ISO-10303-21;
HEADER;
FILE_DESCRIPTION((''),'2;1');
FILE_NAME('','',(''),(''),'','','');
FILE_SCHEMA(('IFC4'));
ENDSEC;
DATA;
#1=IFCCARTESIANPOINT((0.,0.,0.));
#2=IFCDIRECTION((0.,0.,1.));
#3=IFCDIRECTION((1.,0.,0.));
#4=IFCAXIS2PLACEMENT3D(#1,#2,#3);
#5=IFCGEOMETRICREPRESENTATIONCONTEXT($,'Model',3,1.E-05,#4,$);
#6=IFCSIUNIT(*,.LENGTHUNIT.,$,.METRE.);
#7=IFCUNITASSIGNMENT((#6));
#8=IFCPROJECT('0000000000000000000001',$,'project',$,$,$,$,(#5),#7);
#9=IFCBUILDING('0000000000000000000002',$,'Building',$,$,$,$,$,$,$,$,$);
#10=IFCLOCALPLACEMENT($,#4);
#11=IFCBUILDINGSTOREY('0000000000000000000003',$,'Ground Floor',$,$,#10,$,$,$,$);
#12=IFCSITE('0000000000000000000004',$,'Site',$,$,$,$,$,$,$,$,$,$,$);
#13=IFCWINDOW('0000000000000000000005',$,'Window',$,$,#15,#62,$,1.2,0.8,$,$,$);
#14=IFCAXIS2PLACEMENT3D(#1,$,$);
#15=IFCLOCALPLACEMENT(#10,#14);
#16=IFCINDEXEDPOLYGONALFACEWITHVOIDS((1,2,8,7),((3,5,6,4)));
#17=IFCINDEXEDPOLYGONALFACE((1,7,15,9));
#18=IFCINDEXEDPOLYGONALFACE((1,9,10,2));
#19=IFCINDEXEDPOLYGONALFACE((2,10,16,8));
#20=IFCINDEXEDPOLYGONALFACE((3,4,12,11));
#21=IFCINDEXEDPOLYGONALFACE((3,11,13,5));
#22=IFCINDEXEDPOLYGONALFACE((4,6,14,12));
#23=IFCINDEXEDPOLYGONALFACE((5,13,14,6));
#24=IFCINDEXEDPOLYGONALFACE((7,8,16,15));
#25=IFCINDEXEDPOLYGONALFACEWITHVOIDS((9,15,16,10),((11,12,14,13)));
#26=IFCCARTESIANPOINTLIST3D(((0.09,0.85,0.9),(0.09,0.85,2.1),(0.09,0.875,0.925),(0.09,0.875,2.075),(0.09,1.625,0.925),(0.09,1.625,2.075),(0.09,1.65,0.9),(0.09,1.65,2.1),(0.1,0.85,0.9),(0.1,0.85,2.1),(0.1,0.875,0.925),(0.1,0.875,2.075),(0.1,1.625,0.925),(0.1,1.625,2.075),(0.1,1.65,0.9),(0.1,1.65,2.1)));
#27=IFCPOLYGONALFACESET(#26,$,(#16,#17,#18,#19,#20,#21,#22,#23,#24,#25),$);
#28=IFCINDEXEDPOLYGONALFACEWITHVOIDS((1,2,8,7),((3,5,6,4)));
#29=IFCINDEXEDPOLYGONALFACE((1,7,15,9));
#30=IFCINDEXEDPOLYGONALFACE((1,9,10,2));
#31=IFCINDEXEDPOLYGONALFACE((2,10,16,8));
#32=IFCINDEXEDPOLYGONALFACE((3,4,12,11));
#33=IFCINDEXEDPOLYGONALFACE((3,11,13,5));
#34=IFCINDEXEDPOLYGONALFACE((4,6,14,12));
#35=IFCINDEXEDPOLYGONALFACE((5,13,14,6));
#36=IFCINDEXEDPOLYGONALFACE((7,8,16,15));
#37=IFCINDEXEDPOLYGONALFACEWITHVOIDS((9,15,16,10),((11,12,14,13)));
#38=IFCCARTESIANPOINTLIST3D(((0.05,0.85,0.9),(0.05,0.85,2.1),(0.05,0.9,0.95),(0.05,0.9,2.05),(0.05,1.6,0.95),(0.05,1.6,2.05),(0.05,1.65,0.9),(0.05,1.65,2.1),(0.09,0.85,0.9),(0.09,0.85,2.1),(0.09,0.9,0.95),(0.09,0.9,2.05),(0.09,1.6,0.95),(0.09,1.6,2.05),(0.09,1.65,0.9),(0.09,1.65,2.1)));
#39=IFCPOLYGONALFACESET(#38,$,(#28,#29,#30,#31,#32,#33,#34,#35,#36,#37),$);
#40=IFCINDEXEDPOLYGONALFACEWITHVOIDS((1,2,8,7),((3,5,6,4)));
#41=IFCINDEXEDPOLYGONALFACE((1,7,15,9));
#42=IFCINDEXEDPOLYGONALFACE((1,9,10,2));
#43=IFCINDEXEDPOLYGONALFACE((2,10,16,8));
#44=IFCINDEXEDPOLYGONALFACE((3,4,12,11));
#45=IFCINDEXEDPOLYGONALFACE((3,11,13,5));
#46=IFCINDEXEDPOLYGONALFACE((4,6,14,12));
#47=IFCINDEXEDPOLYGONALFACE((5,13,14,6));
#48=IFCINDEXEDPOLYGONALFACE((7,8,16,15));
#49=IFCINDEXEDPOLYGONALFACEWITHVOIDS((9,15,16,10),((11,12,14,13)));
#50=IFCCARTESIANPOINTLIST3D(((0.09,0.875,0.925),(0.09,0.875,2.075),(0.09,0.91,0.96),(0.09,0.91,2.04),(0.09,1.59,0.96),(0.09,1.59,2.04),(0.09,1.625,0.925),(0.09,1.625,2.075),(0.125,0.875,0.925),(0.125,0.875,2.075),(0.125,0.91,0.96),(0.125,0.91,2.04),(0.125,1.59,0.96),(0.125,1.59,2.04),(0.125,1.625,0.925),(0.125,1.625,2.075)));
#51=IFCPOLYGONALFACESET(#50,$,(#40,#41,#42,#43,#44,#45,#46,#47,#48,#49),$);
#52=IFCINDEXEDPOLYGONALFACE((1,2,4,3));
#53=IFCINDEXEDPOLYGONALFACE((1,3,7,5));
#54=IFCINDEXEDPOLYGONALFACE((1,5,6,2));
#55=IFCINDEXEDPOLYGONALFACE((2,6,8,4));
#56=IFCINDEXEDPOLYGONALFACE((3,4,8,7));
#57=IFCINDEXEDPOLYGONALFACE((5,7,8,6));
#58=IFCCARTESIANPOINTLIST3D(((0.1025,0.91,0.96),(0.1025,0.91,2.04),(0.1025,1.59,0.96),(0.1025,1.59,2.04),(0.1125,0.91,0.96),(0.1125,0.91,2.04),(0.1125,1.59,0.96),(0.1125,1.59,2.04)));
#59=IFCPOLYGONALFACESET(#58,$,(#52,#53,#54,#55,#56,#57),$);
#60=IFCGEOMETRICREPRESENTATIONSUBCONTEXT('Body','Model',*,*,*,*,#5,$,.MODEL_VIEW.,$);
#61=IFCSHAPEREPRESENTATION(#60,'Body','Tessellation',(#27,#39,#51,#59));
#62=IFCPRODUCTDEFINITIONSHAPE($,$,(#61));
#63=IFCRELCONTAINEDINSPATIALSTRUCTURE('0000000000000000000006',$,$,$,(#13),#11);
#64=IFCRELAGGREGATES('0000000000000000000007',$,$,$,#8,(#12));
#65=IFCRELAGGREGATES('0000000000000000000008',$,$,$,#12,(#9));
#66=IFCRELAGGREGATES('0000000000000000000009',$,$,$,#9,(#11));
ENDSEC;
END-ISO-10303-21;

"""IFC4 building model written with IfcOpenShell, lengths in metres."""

from ifc_helpers import new_model, si_unit, frame, origin_with_axes, place, context, subcontext, project, spatial, line, indexed_curve, outline, extrude, element, save


model = new_model("IFC4")

# Units and contexts
model_context = context("Model", 3, precision=1e-05, world=origin_with_axes())
body_context = subcontext(model_context, "Body", "Model", "MODEL_VIEW")
ifc_project = project(units=[si_unit("LENGTHUNIT", "METRE")], contexts=[model_context])

# Site, building, storey
site = spatial("IfcSite", under=ifc_project, Name="Site")
building = spatial("IfcBuilding", under=site, Name="Building")
storey_placement = place(None, origin_with_axes())
storey = spatial("IfcBuildingStorey", under=building, at=storey_placement, Name="Ground Floor")

# Window
window_1_placement = place(storey_placement, frame((0.0, 1.65, 0.9), z_axis=(0.0, 0.0, 1.0), x_axis=(0.0, -1.0, 0.0)))
element("IfcWindow", 1, at=window_1_placement, inside=storey, Name="Window", OverallHeight=1.2, OverallWidth=0.8, context=body_context, shape_type="SweptSolid", body=[
    extrude(outline(indexed_curve([(0.0, 0.0), (0.8, 0.0), (0.8, 1.2), (0.0, 1.2)], segments=[line(1, 2, 3, 4, 1)]), holes=[indexed_curve([(0.025, 0.025), (0.775, 0.025), (0.775, 1.175), (0.025, 1.175)], segments=[line(1, 2, 3, 4, 1)])]), frame((0.0, 0.09, 0.0), z_axis=(0.0, -1.0, 0.0), x_axis=(1.0, 0.0, 0.0)), (0.0, 0.0, -1.0), 0.01),
    extrude(outline(indexed_curve([(0.0, 0.0), (0.8, 0.0), (0.8, 1.2), (0.0, 1.2)], segments=[line(1, 2, 3, 4, 1)]), holes=[indexed_curve([(0.05, 0.05), (0.75, 0.05), (0.75, 1.15), (0.05, 1.15)], segments=[line(1, 2, 3, 4, 1)])]), frame((0.0, 0.05, 0.0), z_axis=(0.0, -1.0, 0.0), x_axis=(1.0, 0.0, 0.0)), (0.0, 0.0, -1.0), 0.04),
    extrude(outline(indexed_curve([(0.0, 0.0), (0.75, 0.0), (0.75, 1.15), (0.0, 1.15)], segments=[line(1, 2, 3, 4, 1)]), holes=[indexed_curve([(0.035, 0.035), (0.715, 0.035), (0.715, 1.115), (0.035, 1.115)], segments=[line(1, 2, 3, 4, 1)])]), frame((0.025, 0.09, 0.025), z_axis=(0.0, -1.0, 0.0), x_axis=(1.0, 0.0, 0.0)), (0.0, 0.0, -1.0), 0.035),
    extrude(outline(indexed_curve([(0.035, 0.035), (0.715, 0.035), (0.715, 1.115), (0.035, 1.115)], segments=[line(1, 2, 3, 4, 1)])), frame((0.025, 0.1025, 0.025), z_axis=(0.0, -1.0, 0.0), x_axis=(1.0, 0.0, 0.0)), (0.0, 0.0, -1.0), 0.01),
])

save(model, "model.ifc")
